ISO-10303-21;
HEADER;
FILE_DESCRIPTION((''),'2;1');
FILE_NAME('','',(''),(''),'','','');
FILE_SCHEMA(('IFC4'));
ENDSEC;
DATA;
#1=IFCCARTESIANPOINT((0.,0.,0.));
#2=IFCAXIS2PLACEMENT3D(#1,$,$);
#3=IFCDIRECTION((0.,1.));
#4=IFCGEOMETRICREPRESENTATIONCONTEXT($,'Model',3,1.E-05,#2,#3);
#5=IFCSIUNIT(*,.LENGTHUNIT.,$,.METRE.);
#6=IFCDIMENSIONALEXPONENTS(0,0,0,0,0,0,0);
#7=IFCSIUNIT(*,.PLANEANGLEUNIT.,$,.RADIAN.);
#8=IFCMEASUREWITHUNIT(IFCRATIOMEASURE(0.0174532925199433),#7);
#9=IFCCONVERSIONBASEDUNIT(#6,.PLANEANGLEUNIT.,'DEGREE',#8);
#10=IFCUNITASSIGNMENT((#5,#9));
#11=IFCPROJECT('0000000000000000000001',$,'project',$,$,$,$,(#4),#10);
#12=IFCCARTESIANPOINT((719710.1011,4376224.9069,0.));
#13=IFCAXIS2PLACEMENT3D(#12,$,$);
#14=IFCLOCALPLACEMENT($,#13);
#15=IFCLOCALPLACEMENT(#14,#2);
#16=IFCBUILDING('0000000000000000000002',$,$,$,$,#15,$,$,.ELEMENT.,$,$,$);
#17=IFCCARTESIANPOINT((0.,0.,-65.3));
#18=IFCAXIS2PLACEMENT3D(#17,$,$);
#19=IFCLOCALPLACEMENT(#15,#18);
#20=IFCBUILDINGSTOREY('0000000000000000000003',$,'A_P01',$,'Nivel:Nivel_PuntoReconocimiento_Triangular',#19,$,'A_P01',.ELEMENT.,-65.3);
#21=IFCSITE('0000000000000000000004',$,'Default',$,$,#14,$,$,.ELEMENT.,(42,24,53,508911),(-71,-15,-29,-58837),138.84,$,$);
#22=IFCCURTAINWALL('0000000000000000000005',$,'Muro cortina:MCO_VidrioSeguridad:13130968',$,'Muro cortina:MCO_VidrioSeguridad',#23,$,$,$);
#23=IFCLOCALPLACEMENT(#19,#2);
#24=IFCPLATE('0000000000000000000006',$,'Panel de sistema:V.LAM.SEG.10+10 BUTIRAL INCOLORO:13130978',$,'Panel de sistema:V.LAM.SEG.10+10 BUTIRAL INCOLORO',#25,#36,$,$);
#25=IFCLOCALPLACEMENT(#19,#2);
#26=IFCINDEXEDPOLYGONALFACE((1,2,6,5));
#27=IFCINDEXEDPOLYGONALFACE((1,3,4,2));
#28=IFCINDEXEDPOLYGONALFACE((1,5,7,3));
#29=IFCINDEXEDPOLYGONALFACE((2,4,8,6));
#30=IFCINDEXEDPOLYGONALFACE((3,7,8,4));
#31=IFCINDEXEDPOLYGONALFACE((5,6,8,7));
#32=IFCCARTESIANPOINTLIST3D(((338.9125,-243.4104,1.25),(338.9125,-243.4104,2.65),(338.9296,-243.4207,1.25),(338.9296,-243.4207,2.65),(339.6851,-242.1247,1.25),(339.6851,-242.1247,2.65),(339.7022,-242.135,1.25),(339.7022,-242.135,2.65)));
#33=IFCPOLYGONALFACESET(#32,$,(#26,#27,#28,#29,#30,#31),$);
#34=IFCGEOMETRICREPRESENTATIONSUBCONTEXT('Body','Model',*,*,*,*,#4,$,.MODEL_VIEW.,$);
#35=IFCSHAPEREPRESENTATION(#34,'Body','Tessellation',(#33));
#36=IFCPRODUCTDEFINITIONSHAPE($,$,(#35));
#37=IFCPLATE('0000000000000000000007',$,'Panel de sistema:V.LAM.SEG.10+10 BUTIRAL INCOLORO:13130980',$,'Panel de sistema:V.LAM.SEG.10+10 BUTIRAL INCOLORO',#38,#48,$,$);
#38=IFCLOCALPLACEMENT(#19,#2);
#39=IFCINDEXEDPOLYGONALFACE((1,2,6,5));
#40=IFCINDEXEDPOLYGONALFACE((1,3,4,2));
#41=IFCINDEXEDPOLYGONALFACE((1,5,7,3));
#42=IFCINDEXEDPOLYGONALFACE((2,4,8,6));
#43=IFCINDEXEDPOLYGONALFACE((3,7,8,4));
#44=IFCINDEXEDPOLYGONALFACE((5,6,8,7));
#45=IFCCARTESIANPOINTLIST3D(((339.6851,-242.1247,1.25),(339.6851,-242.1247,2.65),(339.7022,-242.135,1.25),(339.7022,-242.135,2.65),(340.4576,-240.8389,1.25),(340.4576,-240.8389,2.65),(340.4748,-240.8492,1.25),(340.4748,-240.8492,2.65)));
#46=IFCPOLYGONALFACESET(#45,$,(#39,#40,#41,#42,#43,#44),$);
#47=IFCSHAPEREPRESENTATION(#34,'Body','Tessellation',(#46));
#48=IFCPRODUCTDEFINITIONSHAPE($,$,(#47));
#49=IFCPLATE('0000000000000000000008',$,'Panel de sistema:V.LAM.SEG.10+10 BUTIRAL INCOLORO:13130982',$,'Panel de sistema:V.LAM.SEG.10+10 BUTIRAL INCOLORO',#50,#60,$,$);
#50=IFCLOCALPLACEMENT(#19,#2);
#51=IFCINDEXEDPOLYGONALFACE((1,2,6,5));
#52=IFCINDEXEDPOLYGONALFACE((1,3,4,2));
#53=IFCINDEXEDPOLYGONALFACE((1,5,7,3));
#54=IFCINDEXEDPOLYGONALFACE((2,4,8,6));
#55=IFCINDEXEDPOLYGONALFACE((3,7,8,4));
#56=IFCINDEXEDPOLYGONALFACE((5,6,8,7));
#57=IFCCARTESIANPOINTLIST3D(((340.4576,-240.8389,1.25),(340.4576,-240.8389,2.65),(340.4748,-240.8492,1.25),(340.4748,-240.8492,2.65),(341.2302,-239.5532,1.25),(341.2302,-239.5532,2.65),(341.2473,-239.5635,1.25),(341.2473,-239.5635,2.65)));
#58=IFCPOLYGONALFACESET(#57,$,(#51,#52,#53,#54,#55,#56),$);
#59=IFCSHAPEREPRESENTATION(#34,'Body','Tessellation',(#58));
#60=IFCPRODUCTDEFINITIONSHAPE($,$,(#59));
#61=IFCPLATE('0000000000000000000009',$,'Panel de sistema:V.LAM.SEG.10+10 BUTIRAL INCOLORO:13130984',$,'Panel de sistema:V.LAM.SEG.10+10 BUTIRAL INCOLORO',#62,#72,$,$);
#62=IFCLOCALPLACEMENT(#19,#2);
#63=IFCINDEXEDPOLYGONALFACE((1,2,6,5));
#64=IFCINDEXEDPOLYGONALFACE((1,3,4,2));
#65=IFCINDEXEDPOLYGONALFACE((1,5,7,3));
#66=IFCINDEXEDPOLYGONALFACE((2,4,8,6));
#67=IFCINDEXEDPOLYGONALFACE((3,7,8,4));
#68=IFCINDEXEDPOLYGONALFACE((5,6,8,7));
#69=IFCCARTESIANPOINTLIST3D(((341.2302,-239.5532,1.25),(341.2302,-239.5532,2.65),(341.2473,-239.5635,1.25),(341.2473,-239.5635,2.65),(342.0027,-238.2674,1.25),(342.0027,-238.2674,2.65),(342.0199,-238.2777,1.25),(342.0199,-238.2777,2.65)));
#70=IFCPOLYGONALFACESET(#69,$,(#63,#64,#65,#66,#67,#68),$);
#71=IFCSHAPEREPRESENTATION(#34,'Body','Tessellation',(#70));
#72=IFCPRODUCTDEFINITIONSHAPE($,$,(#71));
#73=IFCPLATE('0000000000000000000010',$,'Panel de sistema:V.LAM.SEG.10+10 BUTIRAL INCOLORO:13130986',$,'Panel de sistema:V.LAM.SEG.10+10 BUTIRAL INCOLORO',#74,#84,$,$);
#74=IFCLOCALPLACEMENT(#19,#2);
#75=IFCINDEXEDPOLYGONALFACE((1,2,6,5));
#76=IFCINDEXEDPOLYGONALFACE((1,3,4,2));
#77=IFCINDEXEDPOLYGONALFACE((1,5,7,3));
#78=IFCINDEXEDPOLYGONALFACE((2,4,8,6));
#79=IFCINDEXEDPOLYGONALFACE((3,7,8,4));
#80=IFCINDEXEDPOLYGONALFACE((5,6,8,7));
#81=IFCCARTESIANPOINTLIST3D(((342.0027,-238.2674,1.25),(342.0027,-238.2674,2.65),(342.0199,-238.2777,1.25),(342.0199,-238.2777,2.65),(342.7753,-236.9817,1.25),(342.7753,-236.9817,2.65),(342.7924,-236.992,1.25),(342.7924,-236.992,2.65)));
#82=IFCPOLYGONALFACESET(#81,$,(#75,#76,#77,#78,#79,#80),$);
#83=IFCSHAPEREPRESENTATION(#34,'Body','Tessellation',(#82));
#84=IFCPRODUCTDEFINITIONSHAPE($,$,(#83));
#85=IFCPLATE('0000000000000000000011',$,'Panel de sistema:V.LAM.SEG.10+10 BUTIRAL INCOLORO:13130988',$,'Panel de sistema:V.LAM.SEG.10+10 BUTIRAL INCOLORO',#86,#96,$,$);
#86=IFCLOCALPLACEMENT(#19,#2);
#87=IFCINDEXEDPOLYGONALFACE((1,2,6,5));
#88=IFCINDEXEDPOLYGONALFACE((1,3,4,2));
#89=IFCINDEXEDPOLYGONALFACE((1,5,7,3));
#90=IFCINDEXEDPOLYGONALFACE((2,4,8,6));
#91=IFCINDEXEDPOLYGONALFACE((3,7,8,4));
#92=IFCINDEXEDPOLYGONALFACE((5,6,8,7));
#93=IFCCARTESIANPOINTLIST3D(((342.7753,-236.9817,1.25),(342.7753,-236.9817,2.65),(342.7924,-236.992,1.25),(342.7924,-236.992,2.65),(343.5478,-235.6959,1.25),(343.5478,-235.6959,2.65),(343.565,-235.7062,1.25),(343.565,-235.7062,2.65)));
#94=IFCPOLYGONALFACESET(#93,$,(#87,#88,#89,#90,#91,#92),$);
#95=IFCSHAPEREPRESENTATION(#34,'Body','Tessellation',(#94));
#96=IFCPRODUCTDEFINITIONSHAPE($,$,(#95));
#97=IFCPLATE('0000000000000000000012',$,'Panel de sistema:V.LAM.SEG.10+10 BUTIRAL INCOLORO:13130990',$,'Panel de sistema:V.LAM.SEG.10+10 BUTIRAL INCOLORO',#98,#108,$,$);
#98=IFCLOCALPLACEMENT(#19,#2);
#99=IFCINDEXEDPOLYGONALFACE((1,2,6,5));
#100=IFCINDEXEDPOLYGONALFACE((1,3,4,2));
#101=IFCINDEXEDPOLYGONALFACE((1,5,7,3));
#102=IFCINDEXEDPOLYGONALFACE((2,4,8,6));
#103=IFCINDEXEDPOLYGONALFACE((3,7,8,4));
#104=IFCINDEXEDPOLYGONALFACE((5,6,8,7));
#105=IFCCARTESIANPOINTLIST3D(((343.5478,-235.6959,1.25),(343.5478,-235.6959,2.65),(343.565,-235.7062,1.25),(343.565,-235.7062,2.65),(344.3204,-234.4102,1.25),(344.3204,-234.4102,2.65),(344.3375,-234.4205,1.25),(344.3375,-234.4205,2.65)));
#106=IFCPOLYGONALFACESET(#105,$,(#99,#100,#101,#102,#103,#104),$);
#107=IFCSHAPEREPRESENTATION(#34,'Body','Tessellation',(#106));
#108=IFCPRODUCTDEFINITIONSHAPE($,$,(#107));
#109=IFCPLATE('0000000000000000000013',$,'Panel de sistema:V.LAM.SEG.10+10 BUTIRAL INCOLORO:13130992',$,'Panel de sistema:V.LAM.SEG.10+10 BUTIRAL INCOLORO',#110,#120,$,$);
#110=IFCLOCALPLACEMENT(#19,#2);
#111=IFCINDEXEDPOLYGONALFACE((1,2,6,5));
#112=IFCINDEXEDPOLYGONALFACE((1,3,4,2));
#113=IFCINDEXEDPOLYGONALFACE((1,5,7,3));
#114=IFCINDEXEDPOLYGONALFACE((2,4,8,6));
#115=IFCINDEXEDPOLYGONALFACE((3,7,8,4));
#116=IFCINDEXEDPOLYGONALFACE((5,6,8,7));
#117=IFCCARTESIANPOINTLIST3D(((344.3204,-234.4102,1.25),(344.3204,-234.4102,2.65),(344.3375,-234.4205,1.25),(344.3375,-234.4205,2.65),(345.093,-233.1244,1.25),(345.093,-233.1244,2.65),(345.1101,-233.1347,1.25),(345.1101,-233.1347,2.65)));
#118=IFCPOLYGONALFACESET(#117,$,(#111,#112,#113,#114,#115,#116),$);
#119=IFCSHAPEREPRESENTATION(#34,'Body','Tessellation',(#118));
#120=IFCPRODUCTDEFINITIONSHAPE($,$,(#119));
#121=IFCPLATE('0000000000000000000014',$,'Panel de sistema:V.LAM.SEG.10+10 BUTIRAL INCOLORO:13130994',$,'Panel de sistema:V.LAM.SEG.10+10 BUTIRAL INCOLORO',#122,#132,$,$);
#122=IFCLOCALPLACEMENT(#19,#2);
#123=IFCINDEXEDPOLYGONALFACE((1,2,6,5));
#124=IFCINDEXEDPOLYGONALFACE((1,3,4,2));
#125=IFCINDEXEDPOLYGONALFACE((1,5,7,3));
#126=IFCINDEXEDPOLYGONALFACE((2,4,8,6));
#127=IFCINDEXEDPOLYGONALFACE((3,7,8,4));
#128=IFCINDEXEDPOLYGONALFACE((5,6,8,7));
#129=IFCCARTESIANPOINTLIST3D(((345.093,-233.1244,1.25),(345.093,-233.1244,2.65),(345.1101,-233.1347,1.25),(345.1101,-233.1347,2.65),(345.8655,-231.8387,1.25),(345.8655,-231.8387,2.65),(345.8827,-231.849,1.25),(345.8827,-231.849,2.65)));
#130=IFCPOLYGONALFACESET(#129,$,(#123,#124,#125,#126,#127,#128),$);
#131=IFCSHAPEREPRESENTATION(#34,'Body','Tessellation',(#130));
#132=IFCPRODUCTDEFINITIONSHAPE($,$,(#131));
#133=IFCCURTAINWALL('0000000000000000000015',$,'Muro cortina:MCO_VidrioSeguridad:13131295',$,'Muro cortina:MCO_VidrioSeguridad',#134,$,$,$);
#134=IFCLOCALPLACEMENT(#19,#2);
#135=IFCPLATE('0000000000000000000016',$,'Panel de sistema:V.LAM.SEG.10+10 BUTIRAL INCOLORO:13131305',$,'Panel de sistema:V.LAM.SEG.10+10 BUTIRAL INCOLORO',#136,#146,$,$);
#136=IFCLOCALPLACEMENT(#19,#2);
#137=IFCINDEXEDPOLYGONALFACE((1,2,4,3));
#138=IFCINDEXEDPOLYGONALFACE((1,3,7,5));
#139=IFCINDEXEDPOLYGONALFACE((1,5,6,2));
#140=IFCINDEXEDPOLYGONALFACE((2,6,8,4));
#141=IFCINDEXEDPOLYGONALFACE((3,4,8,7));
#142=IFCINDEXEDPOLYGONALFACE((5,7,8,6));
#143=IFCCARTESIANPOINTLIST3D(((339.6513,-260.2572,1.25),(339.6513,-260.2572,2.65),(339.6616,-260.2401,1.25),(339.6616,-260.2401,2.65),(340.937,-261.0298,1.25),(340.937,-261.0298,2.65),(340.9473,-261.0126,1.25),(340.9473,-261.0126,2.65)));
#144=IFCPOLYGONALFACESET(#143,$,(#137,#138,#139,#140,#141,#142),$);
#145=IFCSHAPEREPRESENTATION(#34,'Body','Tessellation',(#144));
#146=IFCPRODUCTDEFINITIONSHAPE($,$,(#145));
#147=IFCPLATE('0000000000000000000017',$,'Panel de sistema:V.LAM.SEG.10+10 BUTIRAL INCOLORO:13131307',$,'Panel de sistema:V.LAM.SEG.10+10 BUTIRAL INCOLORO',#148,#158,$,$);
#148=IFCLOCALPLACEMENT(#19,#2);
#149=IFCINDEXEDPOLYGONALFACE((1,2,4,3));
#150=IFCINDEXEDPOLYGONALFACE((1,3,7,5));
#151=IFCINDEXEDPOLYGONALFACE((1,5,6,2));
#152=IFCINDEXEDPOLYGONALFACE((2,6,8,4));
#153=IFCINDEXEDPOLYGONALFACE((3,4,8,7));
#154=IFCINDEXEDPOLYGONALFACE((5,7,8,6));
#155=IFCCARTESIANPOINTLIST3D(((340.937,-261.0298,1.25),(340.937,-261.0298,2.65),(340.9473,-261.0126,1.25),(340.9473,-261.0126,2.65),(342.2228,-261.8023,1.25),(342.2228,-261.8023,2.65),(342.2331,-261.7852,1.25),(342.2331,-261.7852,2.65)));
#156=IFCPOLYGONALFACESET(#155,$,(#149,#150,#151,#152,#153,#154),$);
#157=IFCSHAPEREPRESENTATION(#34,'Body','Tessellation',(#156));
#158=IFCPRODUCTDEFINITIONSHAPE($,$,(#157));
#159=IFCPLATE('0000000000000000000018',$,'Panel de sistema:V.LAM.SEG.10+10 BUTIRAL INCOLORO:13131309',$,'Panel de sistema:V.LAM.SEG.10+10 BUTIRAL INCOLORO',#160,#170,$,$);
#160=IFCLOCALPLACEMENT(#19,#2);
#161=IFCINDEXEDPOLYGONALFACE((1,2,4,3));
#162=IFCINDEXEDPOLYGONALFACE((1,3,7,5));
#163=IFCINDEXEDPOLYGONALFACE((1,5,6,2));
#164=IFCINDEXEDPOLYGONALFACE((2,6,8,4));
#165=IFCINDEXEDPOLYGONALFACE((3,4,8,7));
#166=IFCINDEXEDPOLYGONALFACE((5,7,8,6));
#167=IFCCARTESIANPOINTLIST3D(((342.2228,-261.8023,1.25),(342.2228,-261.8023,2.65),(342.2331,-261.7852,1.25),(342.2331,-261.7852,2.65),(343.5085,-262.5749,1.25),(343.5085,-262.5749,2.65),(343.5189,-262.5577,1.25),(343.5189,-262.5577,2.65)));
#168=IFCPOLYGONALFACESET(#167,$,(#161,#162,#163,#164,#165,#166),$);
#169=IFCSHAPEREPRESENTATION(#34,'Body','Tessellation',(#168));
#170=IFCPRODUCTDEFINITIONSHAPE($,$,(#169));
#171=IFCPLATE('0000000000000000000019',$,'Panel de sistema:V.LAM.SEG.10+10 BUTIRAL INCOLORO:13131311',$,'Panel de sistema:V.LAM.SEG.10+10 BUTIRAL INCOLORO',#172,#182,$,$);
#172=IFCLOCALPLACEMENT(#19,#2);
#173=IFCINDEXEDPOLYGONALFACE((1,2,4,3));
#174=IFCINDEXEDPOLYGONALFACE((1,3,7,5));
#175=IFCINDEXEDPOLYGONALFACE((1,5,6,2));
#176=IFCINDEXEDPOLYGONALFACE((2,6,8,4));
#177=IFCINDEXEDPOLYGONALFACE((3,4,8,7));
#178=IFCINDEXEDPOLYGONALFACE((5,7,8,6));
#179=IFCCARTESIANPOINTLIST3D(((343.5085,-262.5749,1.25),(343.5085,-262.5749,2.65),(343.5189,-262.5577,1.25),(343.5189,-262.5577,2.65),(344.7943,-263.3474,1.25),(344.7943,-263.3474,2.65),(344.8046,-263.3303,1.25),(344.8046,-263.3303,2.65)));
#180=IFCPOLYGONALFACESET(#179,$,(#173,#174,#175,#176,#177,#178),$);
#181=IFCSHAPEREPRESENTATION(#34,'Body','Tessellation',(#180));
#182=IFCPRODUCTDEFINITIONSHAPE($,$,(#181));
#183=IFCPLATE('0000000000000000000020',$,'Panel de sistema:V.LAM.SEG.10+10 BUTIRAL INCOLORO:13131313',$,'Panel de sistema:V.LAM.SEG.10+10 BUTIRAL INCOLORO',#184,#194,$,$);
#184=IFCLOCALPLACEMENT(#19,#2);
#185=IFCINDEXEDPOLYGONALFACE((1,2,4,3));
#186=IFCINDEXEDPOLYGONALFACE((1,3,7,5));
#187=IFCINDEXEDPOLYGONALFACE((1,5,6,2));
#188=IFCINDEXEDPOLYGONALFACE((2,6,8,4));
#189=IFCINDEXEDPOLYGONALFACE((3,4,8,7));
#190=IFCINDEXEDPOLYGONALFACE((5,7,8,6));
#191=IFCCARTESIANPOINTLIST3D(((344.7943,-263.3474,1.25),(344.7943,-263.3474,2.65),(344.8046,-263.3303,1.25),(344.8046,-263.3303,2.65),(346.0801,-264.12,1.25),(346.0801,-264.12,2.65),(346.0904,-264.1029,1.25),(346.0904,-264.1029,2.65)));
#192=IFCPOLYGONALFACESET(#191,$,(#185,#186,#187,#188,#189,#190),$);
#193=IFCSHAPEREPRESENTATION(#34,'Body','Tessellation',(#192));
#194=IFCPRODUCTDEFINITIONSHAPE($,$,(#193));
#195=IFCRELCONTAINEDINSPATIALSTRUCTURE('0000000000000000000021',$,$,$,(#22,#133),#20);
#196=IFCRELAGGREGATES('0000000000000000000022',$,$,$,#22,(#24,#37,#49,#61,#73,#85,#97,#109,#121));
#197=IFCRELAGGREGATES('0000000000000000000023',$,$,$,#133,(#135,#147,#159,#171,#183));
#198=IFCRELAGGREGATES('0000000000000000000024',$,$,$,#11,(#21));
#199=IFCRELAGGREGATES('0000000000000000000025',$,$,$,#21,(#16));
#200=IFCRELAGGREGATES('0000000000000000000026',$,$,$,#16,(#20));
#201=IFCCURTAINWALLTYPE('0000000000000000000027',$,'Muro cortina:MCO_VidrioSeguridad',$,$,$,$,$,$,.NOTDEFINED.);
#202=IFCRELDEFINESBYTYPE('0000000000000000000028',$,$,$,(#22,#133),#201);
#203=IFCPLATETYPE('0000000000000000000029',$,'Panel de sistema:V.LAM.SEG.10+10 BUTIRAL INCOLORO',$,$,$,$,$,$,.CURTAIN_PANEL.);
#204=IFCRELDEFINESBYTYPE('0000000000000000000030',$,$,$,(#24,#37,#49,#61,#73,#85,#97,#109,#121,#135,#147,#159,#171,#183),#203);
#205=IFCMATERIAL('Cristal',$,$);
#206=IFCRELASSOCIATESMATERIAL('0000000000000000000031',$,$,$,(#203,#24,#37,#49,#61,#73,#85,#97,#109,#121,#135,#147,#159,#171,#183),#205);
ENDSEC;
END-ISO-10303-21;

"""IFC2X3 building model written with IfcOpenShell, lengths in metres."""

from ifc_helpers import new_model, entity, si_unit, converted_unit, direction, frame, origin, origin_2d_with_axis, place, context, subcontext, project, spatial, rectangle, extrude, source, transform, mapped, material, type_object, type_shapes, element, aggregate, save


model = new_model("IFC2X3")

# Units and contexts
model_context = context("Model", 3, precision=1e-05, world=origin(), true_north=direction((0.0, 1.0)))
body_context = subcontext(model_context, "Body", "Model", "MODEL_VIEW")
ifc_project = project(units=[si_unit("LENGTHUNIT", "METRE"), converted_unit("PLANEANGLEUNIT", "DEGREE", entity("IfcRatioMeasure", 0.0174532925199433), si_unit("PLANEANGLEUNIT", "RADIAN"), dimensions=[0, 0, 0, 0, 0, 0, 0])], contexts=[model_context])

# Site, building, storey
site_placement = place(None, frame((719710.1011, 4376224.9069, 0.0)))
site = spatial("IfcSite", under=ifc_project, at=site_placement, Name="Default", CompositionType="ELEMENT", RefLatitude=(42, 24, 53, 508911), RefLongitude=(-71, -15, -29, -58837), RefElevation=138.84)
building_placement = place(site_placement, origin())
building = spatial("IfcBuilding", under=site, at=building_placement, CompositionType="ELEMENT")
storey_placement = place(building_placement, frame((0.0, 0.0, -65.3)))
storey = spatial("IfcBuildingStorey", under=building, at=storey_placement, Name="A_P01", ObjectType="Nivel:Nivel_PuntoReconocimiento_Triangular", LongName="A_P01", CompositionType="ELEMENT", Elevation=-65.3)

# Curtain walls, plates
curtain_wall_type = type_object("IfcCurtainWallType", Name="Muro cortina:MCO_VidrioSeguridad", PredefinedType="NOTDEFINED")
curtain_wall_1_placement = place(storey_placement, frame((0.0, 0.0, 65.3)))
curtain_wall_1 = element("IfcCurtainWall", 1, at=curtain_wall_1_placement, inside=storey, type_object=curtain_wall_type, Name="Muro cortina:MCO_VidrioSeguridad:13130968", ObjectType="Muro cortina:MCO_VidrioSeguridad")
ifc_material_1 = material(Name="Cristal")
plate_type = type_object("IfcPlateType", Name="Panel de sistema:V.LAM.SEG.10+10 BUTIRAL INCOLORO", PredefinedType="CURTAIN_PANEL", material=ifc_material_1)
shared_shape = source(origin(), body_context, "Body", "SweptSolid", [
    extrude(rectangle(XDim=0.02, YDim=1.5, at=origin_2d_with_axis()), frame((0.0, 0.0, 0.0), z_axis=(0.0, 0.0, 1.0), x_axis=(0.0, 1.0, 0.0)), (0.0, 0.0, 1.0), 1.4),
])
type_shapes(plate_type, [shared_shape])
plate_1_placement = place(curtain_wall_1_placement, frame((339.3074, -242.7727, -64.05), z_axis=(0.0, 0.0, 1.0), x_axis=(0.515038, 0.857167, 0.0)))
plate_1 = element("IfcPlate", 2, at=plate_1_placement, type_object=plate_type, material=ifc_material_1, Name="Panel de sistema:V.LAM.SEG.10+10 BUTIRAL INCOLORO:13130978", ObjectType="Panel de sistema:V.LAM.SEG.10+10 BUTIRAL INCOLORO", context=body_context, shape_type="MappedRepresentation", body=[
    mapped(shared_shape, transform((0.0, 0.0, 0.0), scale=1.0)),
])
plate_2_placement = place(curtain_wall_1_placement, frame((340.0799, -241.487, -64.05), z_axis=(0.0, 0.0, 1.0), x_axis=(0.515038, 0.857167, 0.0)))
plate_2 = element("IfcPlate", 3, at=plate_2_placement, type_object=plate_type, material=ifc_material_1, Name="Panel de sistema:V.LAM.SEG.10+10 BUTIRAL INCOLORO:13130980", ObjectType="Panel de sistema:V.LAM.SEG.10+10 BUTIRAL INCOLORO", context=body_context, shape_type="MappedRepresentation", body=[
    mapped(shared_shape, transform((0.0, 0.0, 0.0), scale=1.0)),
])
plate_3_placement = place(curtain_wall_1_placement, frame((340.8525, -240.2012, -64.05), z_axis=(0.0, 0.0, 1.0), x_axis=(0.515038, 0.857167, 0.0)))
plate_3 = element("IfcPlate", 4, at=plate_3_placement, type_object=plate_type, material=ifc_material_1, Name="Panel de sistema:V.LAM.SEG.10+10 BUTIRAL INCOLORO:13130982", ObjectType="Panel de sistema:V.LAM.SEG.10+10 BUTIRAL INCOLORO", context=body_context, shape_type="MappedRepresentation", body=[
    mapped(shared_shape, transform((0.0, 0.0, 0.0), scale=1.0)),
])
plate_4_placement = place(curtain_wall_1_placement, frame((341.625, -238.9155, -64.05), z_axis=(0.0, 0.0, 1.0), x_axis=(0.515038, 0.857167, 0.0)))
plate_4 = element("IfcPlate", 5, at=plate_4_placement, type_object=plate_type, material=ifc_material_1, Name="Panel de sistema:V.LAM.SEG.10+10 BUTIRAL INCOLORO:13130984", ObjectType="Panel de sistema:V.LAM.SEG.10+10 BUTIRAL INCOLORO", context=body_context, shape_type="MappedRepresentation", body=[
    mapped(shared_shape, transform((0.0, 0.0, 0.0), scale=1.0)),
])
plate_5_placement = place(curtain_wall_1_placement, frame((342.3976, -237.6297, -64.05), z_axis=(0.0, 0.0, 1.0), x_axis=(0.515038, 0.857167, 0.0)))
plate_5 = element("IfcPlate", 6, at=plate_5_placement, type_object=plate_type, material=ifc_material_1, Name="Panel de sistema:V.LAM.SEG.10+10 BUTIRAL INCOLORO:13130986", ObjectType="Panel de sistema:V.LAM.SEG.10+10 BUTIRAL INCOLORO", context=body_context, shape_type="MappedRepresentation", body=[
    mapped(shared_shape, transform((0.0, 0.0, 0.0), scale=1.0)),
])
plate_6_placement = place(curtain_wall_1_placement, frame((343.1701, -236.344, -64.05), z_axis=(0.0, 0.0, 1.0), x_axis=(0.515038, 0.857167, 0.0)))
plate_6 = element("IfcPlate", 7, at=plate_6_placement, type_object=plate_type, material=ifc_material_1, Name="Panel de sistema:V.LAM.SEG.10+10 BUTIRAL INCOLORO:13130988", ObjectType="Panel de sistema:V.LAM.SEG.10+10 BUTIRAL INCOLORO", context=body_context, shape_type="MappedRepresentation", body=[
    mapped(shared_shape, transform((0.0, 0.0, 0.0), scale=1.0)),
])
plate_7_placement = place(curtain_wall_1_placement, frame((343.9427, -235.0582, -64.05), z_axis=(0.0, 0.0, 1.0), x_axis=(0.515038, 0.857167, 0.0)))
plate_7 = element("IfcPlate", 8, at=plate_7_placement, type_object=plate_type, material=ifc_material_1, Name="Panel de sistema:V.LAM.SEG.10+10 BUTIRAL INCOLORO:13130990", ObjectType="Panel de sistema:V.LAM.SEG.10+10 BUTIRAL INCOLORO", context=body_context, shape_type="MappedRepresentation", body=[
    mapped(shared_shape, transform((0.0, 0.0, 0.0), scale=1.0)),
])
plate_8_placement = place(curtain_wall_1_placement, frame((344.7153, -233.7725, -64.05), z_axis=(0.0, 0.0, 1.0), x_axis=(0.515038, 0.857167, 0.0)))
plate_8 = element("IfcPlate", 9, at=plate_8_placement, type_object=plate_type, material=ifc_material_1, Name="Panel de sistema:V.LAM.SEG.10+10 BUTIRAL INCOLORO:13130992", ObjectType="Panel de sistema:V.LAM.SEG.10+10 BUTIRAL INCOLORO", context=body_context, shape_type="MappedRepresentation", body=[
    mapped(shared_shape, transform((0.0, 0.0, 0.0), scale=1.0)),
])
plate_9_placement = place(curtain_wall_1_placement, frame((345.4878, -232.4867, -64.05), z_axis=(0.0, 0.0, 1.0), x_axis=(0.515038, 0.857167, 0.0)))
plate_9 = element("IfcPlate", 10, at=plate_9_placement, type_object=plate_type, material=ifc_material_1, Name="Panel de sistema:V.LAM.SEG.10+10 BUTIRAL INCOLORO:13130994", ObjectType="Panel de sistema:V.LAM.SEG.10+10 BUTIRAL INCOLORO", context=body_context, shape_type="MappedRepresentation", body=[
    mapped(shared_shape, transform((0.0, 0.0, 0.0), scale=1.0)),
])
aggregate(curtain_wall_1, [plate_1, plate_2, plate_3, plate_4, plate_5, plate_6, plate_7, plate_8, plate_9])
curtain_wall_2_placement = place(storey_placement, frame((0.0, 0.0, 65.3)))
curtain_wall_2 = element("IfcCurtainWall", 11, at=curtain_wall_2_placement, inside=storey, type_object=curtain_wall_type, Name="Muro cortina:MCO_VidrioSeguridad:13131295", ObjectType="Muro cortina:MCO_VidrioSeguridad")
plate_10_placement = place(curtain_wall_2_placement, frame((340.2993, -260.6349, -64.05), z_axis=(0.0, 0.0, 1.0), x_axis=(0.857167, -0.515038, 0.0)))
plate_10 = element("IfcPlate", 12, at=plate_10_placement, type_object=plate_type, material=ifc_material_1, Name="Panel de sistema:V.LAM.SEG.10+10 BUTIRAL INCOLORO:13131305", ObjectType="Panel de sistema:V.LAM.SEG.10+10 BUTIRAL INCOLORO", context=body_context, shape_type="MappedRepresentation", body=[
    mapped(shared_shape, transform((0.0, 0.0, 0.0), scale=1.0)),
])
plate_11_placement = place(curtain_wall_2_placement, frame((341.5851, -261.4075, -64.05), z_axis=(0.0, 0.0, 1.0), x_axis=(0.857167, -0.515038, 0.0)))
plate_11 = element("IfcPlate", 13, at=plate_11_placement, type_object=plate_type, material=ifc_material_1, Name="Panel de sistema:V.LAM.SEG.10+10 BUTIRAL INCOLORO:13131307", ObjectType="Panel de sistema:V.LAM.SEG.10+10 BUTIRAL INCOLORO", context=body_context, shape_type="MappedRepresentation", body=[
    mapped(shared_shape, transform((0.0, 0.0, 0.0), scale=1.0)),
])
plate_12_placement = place(curtain_wall_2_placement, frame((342.8708, -262.18, -64.05), z_axis=(0.0, 0.0, 1.0), x_axis=(0.857167, -0.515038, 0.0)))
plate_12 = element("IfcPlate", 14, at=plate_12_placement, type_object=plate_type, material=ifc_material_1, Name="Panel de sistema:V.LAM.SEG.10+10 BUTIRAL INCOLORO:13131309", ObjectType="Panel de sistema:V.LAM.SEG.10+10 BUTIRAL INCOLORO", context=body_context, shape_type="MappedRepresentation", body=[
    mapped(shared_shape, transform((0.0, 0.0, 0.0), scale=1.0)),
])
plate_13_placement = place(curtain_wall_2_placement, frame((344.1566, -262.9526, -64.05), z_axis=(0.0, 0.0, 1.0), x_axis=(0.857167, -0.515038, 0.0)))
plate_13 = element("IfcPlate", 15, at=plate_13_placement, type_object=plate_type, material=ifc_material_1, Name="Panel de sistema:V.LAM.SEG.10+10 BUTIRAL INCOLORO:13131311", ObjectType="Panel de sistema:V.LAM.SEG.10+10 BUTIRAL INCOLORO", context=body_context, shape_type="MappedRepresentation", body=[
    mapped(shared_shape, transform((0.0, 0.0, 0.0), scale=1.0)),
])
plate_14_placement = place(curtain_wall_2_placement, frame((345.4423, -263.7251, -64.05), z_axis=(0.0, 0.0, 1.0), x_axis=(0.857167, -0.515038, 0.0)))
plate_14 = element("IfcPlate", 16, at=plate_14_placement, type_object=plate_type, material=ifc_material_1, Name="Panel de sistema:V.LAM.SEG.10+10 BUTIRAL INCOLORO:13131313", ObjectType="Panel de sistema:V.LAM.SEG.10+10 BUTIRAL INCOLORO", context=body_context, shape_type="MappedRepresentation", body=[
    mapped(shared_shape, transform((0.0, 0.0, 0.0), scale=1.0)),
])
aggregate(curtain_wall_2, [plate_10, plate_11, plate_12, plate_13, plate_14])

save(model, "model.ifc")
